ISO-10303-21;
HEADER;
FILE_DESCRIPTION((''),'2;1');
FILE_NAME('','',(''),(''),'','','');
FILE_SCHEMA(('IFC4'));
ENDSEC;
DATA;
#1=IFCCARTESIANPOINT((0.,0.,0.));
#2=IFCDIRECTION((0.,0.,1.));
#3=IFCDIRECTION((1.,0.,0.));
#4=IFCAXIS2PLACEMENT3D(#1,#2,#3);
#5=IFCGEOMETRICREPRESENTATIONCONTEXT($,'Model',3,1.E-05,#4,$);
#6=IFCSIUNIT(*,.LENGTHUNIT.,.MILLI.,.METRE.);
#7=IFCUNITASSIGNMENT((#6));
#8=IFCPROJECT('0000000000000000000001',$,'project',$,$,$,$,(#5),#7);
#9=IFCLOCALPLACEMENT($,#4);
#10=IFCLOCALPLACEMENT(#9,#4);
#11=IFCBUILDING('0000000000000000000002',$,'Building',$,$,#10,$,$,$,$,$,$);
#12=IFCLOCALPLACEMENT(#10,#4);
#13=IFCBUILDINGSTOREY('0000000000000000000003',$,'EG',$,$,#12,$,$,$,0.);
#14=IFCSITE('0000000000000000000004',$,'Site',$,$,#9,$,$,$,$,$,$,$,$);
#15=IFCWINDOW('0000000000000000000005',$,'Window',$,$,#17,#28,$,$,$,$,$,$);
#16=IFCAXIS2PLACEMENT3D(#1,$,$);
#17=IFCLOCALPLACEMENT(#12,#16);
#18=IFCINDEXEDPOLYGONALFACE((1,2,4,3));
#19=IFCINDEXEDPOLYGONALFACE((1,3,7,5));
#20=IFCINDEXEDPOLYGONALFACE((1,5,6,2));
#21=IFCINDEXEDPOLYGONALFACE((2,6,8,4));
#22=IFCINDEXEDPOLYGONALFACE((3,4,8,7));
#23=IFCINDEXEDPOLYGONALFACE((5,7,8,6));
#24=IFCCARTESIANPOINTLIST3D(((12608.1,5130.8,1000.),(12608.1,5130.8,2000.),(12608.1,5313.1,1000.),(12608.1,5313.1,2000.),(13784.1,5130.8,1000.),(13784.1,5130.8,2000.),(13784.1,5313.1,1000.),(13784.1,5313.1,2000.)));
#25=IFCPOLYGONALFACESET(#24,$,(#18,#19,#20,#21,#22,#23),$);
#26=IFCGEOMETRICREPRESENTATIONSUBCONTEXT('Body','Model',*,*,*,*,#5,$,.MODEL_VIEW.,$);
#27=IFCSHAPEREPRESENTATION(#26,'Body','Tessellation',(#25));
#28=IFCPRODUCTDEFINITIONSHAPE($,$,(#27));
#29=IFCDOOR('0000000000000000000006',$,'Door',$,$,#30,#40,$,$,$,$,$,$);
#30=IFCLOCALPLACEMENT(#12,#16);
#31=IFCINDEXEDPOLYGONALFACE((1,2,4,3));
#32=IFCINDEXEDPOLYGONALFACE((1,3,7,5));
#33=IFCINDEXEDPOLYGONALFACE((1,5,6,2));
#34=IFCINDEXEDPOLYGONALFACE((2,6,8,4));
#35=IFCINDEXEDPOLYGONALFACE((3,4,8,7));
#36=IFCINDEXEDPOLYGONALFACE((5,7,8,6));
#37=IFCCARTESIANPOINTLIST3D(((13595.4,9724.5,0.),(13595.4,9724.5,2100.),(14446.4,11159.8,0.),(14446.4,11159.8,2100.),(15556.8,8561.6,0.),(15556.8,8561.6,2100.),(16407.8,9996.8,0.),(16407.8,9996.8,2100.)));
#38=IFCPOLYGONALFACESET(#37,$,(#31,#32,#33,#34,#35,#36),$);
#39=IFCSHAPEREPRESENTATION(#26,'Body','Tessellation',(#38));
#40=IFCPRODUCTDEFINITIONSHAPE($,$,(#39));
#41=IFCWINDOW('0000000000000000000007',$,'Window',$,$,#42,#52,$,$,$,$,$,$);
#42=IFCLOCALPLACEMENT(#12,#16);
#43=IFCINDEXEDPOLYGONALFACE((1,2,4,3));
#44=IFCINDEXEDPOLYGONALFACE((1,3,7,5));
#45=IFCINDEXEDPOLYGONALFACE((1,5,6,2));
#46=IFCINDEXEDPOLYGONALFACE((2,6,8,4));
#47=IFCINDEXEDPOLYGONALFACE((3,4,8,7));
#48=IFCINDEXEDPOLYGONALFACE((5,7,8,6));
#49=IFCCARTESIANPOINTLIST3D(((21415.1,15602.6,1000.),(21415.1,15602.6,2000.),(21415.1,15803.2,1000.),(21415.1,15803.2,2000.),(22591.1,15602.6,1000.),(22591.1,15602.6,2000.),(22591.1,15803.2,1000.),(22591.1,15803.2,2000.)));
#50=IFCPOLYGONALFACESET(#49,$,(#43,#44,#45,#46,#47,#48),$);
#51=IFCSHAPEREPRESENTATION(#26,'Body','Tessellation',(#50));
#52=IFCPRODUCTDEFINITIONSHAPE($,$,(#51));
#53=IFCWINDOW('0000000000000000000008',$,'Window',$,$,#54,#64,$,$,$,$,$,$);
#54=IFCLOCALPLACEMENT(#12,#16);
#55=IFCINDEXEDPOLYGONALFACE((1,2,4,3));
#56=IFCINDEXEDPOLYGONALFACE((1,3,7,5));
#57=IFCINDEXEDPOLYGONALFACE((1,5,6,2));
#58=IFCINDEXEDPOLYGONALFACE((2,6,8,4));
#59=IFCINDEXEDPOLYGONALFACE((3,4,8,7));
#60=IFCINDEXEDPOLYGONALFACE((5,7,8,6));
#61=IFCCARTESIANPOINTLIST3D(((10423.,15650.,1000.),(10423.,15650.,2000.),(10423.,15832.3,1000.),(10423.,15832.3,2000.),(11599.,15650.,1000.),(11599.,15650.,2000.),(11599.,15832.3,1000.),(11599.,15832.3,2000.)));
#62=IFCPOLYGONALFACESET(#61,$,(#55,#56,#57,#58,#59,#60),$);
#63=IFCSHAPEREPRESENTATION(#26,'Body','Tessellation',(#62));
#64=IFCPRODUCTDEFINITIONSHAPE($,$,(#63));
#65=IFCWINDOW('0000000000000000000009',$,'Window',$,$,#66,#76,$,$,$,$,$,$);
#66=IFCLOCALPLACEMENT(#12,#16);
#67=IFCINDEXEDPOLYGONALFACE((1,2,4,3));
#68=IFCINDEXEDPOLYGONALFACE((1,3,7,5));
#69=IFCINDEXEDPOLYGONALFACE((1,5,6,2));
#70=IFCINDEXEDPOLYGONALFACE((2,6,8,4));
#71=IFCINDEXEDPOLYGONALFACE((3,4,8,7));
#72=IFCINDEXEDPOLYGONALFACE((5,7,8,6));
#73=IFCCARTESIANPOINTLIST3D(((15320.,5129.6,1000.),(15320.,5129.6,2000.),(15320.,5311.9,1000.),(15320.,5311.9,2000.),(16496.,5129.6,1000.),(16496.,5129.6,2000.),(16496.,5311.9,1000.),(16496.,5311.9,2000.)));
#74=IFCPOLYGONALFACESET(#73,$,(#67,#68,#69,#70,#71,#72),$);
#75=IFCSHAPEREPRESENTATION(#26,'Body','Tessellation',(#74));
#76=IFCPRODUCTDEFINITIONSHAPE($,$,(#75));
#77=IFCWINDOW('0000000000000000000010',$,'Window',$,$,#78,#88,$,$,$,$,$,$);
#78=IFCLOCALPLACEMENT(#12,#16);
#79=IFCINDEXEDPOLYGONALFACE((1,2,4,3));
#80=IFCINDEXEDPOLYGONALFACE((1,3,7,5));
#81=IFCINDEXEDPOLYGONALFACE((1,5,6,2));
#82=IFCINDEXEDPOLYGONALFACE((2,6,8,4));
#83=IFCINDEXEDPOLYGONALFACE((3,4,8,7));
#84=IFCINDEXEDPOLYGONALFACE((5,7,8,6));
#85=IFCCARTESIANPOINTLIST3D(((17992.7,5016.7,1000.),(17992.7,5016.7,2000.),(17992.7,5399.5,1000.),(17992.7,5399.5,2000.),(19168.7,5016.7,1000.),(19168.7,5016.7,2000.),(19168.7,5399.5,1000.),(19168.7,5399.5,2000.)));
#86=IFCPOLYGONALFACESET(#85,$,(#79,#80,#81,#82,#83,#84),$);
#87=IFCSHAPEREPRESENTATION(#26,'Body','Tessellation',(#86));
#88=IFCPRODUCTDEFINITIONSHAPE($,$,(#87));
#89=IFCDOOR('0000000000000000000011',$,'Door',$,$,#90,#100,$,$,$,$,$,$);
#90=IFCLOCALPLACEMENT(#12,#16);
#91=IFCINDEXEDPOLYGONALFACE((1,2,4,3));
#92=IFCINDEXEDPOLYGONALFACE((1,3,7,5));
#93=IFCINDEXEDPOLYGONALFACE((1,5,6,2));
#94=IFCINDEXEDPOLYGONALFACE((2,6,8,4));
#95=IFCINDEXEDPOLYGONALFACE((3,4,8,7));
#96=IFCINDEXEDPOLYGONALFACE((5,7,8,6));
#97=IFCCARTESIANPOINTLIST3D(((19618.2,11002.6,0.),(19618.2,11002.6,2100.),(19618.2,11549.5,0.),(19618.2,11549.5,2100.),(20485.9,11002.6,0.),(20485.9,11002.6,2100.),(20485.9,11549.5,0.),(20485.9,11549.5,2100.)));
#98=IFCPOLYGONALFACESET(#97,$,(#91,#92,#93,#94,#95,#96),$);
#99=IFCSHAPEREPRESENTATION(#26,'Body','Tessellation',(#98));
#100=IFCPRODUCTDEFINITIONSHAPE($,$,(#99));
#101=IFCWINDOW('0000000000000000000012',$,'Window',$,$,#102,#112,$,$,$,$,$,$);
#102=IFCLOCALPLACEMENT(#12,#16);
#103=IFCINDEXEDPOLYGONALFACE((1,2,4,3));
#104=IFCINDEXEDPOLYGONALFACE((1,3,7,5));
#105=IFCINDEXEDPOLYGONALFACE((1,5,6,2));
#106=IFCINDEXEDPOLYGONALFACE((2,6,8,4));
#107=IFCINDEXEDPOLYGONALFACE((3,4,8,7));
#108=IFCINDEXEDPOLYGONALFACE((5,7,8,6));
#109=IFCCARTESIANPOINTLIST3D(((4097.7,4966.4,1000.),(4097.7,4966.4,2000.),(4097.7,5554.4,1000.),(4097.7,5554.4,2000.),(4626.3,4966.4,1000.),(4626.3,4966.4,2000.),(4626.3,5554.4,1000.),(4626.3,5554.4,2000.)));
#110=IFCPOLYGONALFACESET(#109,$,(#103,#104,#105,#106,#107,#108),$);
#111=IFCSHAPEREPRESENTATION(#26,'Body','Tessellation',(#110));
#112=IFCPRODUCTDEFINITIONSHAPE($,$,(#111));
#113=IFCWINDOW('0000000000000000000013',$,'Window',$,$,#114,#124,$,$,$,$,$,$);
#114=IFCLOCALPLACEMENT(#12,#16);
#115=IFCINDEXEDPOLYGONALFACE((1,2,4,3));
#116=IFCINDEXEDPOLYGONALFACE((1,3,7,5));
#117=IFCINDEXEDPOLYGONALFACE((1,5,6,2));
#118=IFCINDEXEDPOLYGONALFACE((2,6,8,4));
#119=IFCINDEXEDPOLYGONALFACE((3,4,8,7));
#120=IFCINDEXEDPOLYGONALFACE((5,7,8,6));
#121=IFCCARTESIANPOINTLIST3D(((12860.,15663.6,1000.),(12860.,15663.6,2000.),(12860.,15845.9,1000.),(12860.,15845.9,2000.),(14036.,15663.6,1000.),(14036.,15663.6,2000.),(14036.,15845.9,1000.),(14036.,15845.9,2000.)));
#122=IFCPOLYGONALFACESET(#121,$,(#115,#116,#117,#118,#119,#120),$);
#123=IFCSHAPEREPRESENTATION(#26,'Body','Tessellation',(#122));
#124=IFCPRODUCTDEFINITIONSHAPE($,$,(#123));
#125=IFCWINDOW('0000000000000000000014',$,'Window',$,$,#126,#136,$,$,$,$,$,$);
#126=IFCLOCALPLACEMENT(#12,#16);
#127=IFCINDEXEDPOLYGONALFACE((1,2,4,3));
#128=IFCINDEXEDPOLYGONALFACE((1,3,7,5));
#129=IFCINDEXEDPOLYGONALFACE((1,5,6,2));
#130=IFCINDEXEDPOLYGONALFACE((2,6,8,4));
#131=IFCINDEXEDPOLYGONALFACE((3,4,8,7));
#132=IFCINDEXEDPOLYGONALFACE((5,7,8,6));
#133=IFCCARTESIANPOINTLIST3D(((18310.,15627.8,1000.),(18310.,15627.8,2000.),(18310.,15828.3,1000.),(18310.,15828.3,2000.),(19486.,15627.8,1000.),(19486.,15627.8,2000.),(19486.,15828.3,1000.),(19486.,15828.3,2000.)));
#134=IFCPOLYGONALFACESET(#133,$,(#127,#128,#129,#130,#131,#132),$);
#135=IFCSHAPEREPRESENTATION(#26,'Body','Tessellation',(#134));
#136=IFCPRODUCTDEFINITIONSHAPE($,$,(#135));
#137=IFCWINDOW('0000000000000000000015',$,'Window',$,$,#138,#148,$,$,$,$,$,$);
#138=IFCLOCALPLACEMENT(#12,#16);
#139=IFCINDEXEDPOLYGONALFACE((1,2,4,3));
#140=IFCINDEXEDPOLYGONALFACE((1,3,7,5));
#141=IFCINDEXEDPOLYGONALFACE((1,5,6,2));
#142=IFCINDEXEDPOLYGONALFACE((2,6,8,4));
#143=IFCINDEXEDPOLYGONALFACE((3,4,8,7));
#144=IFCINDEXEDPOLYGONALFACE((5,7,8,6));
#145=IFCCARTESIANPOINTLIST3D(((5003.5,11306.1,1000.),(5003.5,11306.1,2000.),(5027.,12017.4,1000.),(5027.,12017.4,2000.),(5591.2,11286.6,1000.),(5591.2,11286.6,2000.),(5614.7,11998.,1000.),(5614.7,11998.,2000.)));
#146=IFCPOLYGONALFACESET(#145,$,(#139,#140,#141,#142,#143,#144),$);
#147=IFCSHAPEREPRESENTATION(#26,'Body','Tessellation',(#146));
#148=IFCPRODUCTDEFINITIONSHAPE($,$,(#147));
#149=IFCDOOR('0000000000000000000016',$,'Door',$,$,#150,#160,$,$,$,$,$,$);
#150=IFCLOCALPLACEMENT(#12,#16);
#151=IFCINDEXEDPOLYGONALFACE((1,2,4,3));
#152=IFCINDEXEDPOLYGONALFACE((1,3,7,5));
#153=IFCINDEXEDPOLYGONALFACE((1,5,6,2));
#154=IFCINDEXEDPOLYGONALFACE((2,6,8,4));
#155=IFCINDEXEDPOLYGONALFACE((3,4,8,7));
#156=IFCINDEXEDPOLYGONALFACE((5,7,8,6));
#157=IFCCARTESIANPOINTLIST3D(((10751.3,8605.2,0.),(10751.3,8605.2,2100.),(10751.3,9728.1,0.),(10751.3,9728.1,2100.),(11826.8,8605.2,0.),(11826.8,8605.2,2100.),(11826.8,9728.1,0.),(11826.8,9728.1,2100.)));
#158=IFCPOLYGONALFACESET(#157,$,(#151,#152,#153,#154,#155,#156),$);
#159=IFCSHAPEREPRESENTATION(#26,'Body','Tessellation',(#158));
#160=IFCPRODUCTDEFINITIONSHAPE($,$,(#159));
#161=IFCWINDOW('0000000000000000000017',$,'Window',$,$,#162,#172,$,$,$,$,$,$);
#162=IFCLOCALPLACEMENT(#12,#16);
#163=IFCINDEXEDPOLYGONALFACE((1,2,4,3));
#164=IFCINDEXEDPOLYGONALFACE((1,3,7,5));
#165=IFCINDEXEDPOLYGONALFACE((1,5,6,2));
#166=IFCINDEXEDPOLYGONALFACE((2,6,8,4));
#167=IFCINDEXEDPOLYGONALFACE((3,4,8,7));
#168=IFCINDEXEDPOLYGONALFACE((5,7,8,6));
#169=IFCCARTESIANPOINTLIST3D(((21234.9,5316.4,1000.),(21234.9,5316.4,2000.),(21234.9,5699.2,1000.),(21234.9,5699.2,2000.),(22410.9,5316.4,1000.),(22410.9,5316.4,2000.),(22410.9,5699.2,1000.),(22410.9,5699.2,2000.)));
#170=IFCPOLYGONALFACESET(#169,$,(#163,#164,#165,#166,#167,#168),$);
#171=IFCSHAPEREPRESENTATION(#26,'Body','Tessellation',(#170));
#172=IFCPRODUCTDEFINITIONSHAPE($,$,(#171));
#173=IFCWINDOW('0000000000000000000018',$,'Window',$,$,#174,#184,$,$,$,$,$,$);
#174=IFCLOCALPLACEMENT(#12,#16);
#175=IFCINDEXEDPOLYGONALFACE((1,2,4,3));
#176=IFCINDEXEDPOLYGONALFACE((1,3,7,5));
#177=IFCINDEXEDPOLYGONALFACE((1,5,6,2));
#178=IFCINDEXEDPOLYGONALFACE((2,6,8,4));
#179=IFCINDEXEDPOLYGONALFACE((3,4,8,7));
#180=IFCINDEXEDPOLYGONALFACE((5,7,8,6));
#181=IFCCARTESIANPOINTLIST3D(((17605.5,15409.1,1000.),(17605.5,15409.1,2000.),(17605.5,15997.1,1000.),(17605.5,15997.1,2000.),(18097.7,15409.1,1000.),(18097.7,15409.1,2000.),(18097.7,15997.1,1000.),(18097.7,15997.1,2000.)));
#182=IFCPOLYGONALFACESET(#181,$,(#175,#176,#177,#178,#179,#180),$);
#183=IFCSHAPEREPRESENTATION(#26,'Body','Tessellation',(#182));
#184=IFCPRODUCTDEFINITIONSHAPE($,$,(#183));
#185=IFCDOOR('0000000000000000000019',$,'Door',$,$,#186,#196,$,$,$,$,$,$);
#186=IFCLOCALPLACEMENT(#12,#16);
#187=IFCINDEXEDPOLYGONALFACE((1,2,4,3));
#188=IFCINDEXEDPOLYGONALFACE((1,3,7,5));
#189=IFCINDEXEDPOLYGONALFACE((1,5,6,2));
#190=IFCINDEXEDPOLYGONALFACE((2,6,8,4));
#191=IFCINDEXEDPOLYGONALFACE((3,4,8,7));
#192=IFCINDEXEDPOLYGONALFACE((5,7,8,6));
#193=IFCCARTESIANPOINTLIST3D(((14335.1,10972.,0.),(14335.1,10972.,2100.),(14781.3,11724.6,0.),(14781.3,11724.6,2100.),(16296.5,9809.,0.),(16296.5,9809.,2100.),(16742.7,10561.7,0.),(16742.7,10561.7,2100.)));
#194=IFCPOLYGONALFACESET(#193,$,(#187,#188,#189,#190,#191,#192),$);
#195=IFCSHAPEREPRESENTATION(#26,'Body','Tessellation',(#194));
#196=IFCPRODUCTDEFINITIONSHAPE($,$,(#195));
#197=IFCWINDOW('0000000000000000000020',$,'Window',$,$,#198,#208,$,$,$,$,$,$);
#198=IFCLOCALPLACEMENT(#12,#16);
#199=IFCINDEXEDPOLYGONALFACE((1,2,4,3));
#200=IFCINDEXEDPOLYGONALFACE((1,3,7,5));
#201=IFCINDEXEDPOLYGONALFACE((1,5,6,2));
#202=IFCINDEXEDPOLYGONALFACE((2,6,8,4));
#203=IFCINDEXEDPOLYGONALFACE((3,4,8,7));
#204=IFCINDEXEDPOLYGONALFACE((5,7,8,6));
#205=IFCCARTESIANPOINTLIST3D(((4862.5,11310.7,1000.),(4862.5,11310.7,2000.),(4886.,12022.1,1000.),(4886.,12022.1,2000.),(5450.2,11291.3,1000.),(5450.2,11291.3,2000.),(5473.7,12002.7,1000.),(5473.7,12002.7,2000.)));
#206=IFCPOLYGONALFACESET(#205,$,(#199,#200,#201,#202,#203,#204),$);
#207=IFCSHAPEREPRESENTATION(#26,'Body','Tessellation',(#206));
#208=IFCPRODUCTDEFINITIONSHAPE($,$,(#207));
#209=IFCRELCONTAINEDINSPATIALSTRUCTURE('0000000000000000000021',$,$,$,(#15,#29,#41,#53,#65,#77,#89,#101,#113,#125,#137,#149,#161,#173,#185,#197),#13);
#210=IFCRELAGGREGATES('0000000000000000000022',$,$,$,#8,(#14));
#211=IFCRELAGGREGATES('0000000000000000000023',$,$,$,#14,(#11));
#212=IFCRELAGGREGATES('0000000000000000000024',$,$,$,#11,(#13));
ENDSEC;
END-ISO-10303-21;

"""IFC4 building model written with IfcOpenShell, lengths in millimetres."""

from ifc_helpers import new_model, si_unit, frame, origin_with_axes, place, context, subcontext, project, spatial, rectangle, extrude, element, save


model = new_model("IFC4")

# Units and contexts
model_context = context("Model", 3, precision=1e-05, world=origin_with_axes())
body_context = subcontext(model_context, "Body", "Model", "MODEL_VIEW")
ifc_project = project(units=[si_unit("LENGTHUNIT", "METRE", prefix="MILLI")], contexts=[model_context])

# Site, building, storey
site_placement = place(None, origin_with_axes())
site = spatial("IfcSite", under=ifc_project, at=site_placement, Name="Site")
building_placement = place(site_placement, origin_with_axes())
building = spatial("IfcBuilding", under=site, at=building_placement, Name="Building")
storey_placement = place(building_placement, origin_with_axes())
storey = spatial("IfcBuildingStorey", under=building, at=storey_placement, Name="EG", Elevation=0.0)

# Window
window_1_placement = place(storey_placement, origin_with_axes())
element("IfcWindow", 1, at=window_1_placement, inside=storey, Name="Window", context=body_context, shape_type="SweptSolid", body=[
    extrude(rectangle(XDim=1176.0, YDim=182.3), frame((13196.1, 5222.0, 1000.0), z_axis=(0.0, 0.0, 1.0), x_axis=(1.0, 0.0, 0.0)), (0.0, 0.0, 1.0), 1000.0),
])

# Door
door_1_placement = place(storey_placement, origin_with_axes())
element("IfcDoor", 2, at=door_1_placement, inside=storey, Name="Door", context=body_context, shape_type="SweptSolid", body=[
    extrude(rectangle(XDim=1668.6, YDim=2280.3), frame((15001.6, 9860.7, 0.0), z_axis=(0.0, 0.0, 1.0), x_axis=(-0.510011, -0.860168, 0.0)), (0.0, 0.0, 1.0), 2100.0),
])

# Windows
window_2_placement = place(storey_placement, origin_with_axes())
element("IfcWindow", 3, at=window_2_placement, inside=storey, Name="Window", context=body_context, shape_type="SweptSolid", body=[
    extrude(rectangle(XDim=1176.0, YDim=200.5), frame((22003.1, 15702.9, 1000.0), z_axis=(0.0, 0.0, 1.0), x_axis=(1.0, 0.0, 0.0)), (0.0, 0.0, 1.0), 1000.0),
])
window_3_placement = place(storey_placement, origin_with_axes())
element("IfcWindow", 4, at=window_3_placement, inside=storey, Name="Window", context=body_context, shape_type="SweptSolid", body=[
    extrude(rectangle(XDim=1176.0, YDim=182.3), frame((11011.0, 15741.2, 1000.0), z_axis=(0.0, 0.0, 1.0), x_axis=(1.0, 0.0, 0.0)), (0.0, 0.0, 1.0), 1000.0),
])
window_4_placement = place(storey_placement, origin_with_axes())
element("IfcWindow", 5, at=window_4_placement, inside=storey, Name="Window", context=body_context, shape_type="SweptSolid", body=[
    extrude(rectangle(XDim=1176.0, YDim=182.3), frame((15908.0, 5220.7, 1000.0), z_axis=(0.0, 0.0, 1.0), x_axis=(1.0, 0.0, 0.0)), (0.0, 0.0, 1.0), 1000.0),
])
window_5_placement = place(storey_placement, origin_with_axes())
element("IfcWindow", 6, at=window_5_placement, inside=storey, Name="Window", context=body_context, shape_type="SweptSolid", body=[
    extrude(rectangle(XDim=1176.0, YDim=382.8), frame((18580.7, 5208.1, 1000.0), z_axis=(0.0, 0.0, 1.0), x_axis=(1.0, 0.0, 0.0)), (0.0, 0.0, 1.0), 1000.0),
])

# Door
door_2_placement = place(storey_placement, origin_with_axes())
element("IfcDoor", 7, at=door_2_placement, inside=storey, Name="Door", context=body_context, shape_type="SweptSolid", body=[
    extrude(rectangle(XDim=867.7, YDim=546.9), frame((20052.1, 11276.0, 0.0), z_axis=(0.0, 0.0, 1.0), x_axis=(1.0, 0.0, 0.0)), (0.0, 0.0, 1.0), 2100.0),
])

# Windows
window_6_placement = place(storey_placement, origin_with_axes())
element("IfcWindow", 8, at=window_6_placement, inside=storey, Name="Window", context=body_context, shape_type="SweptSolid", body=[
    extrude(rectangle(XDim=588.0, YDim=528.6), frame((4362.0, 5260.4, 1000.0), z_axis=(0.0, 0.0, 1.0), x_axis=(0.0, 1.0, 0.0)), (0.0, 0.0, 1.0), 1000.0),
])
window_7_placement = place(storey_placement, origin_with_axes())
element("IfcWindow", 9, at=window_7_placement, inside=storey, Name="Window", context=body_context, shape_type="SweptSolid", body=[
    extrude(rectangle(XDim=1176.0, YDim=182.3), frame((13448.0, 15754.8, 1000.0), z_axis=(0.0, 0.0, 1.0), x_axis=(1.0, 0.0, 0.0)), (0.0, 0.0, 1.0), 1000.0),
])
window_8_placement = place(storey_placement, origin_with_axes())
element("IfcWindow", 10, at=window_8_placement, inside=storey, Name="Window", context=body_context, shape_type="SweptSolid", body=[
    extrude(rectangle(XDim=1176.0, YDim=200.5), frame((18898.0, 15728.1, 1000.0), z_axis=(0.0, 0.0, 1.0), x_axis=(1.0, 0.0, 0.0)), (0.0, 0.0, 1.0), 1000.0),
])
window_9_placement = place(storey_placement, origin_with_axes())
element("IfcWindow", 11, at=window_9_placement, inside=storey, Name="Window", context=body_context, shape_type="SweptSolid", body=[
    extrude(rectangle(XDim=588.0, YDim=711.8), frame((5309.1, 11652.0, 1000.0), z_axis=(0.0, 0.0, 1.0), x_axis=(-0.999454, 0.03304, 0.0)), (0.0, 0.0, 1.0), 1000.0),
])

# Door
door_3_placement = place(storey_placement, origin_with_axes())
element("IfcDoor", 12, at=door_3_placement, inside=storey, Name="Door", context=body_context, shape_type="SweptSolid", body=[
    extrude(rectangle(XDim=1122.9, YDim=1075.5), frame((11289.1, 9166.7, 0.0), z_axis=(0.0, 0.0, 1.0), x_axis=(0.0, 1.0, 0.0)), (0.0, 0.0, 1.0), 2100.0),
])

# Windows
window_10_placement = place(storey_placement, origin_with_axes())
element("IfcWindow", 13, at=window_10_placement, inside=storey, Name="Window", context=body_context, shape_type="SweptSolid", body=[
    extrude(rectangle(XDim=1176.0, YDim=382.8), frame((21822.9, 5507.8, 1000.0), z_axis=(0.0, 0.0, 1.0), x_axis=(1.0, 0.0, 0.0)), (0.0, 0.0, 1.0), 1000.0),
])
window_11_placement = place(storey_placement, origin_with_axes())
element("IfcWindow", 14, at=window_11_placement, inside=storey, Name="Window", context=body_context, shape_type="SweptSolid", body=[
    extrude(rectangle(XDim=588.0, YDim=492.2), frame((17851.6, 15703.1, 1000.0), z_axis=(0.0, 0.0, 1.0), x_axis=(0.0, 1.0, 0.0)), (0.0, 0.0, 1.0), 1000.0),
])

# Door
door_4_placement = place(storey_placement, origin_with_axes())
element("IfcDoor", 15, at=door_4_placement, inside=storey, Name="Door", context=body_context, shape_type="SweptSolid", body=[
    extrude(rectangle(XDim=875.0, YDim=2280.3), frame((15538.9, 10766.8, 0.0), z_axis=(0.0, 0.0, 1.0), x_axis=(-0.510011, -0.860168, 0.0)), (0.0, 0.0, 1.0), 2100.0),
])

# Window
window_12_placement = place(storey_placement, origin_with_axes())
element("IfcWindow", 16, at=window_12_placement, inside=storey, Name="Window", context=body_context, shape_type="SweptSolid", body=[
    extrude(rectangle(XDim=588.0, YDim=711.8), frame((5168.1, 11656.7, 1000.0), z_axis=(0.0, 0.0, 1.0), x_axis=(-0.999454, 0.03304, 0.0)), (0.0, 0.0, 1.0), 1000.0),
])

save(model, "model.ifc")
